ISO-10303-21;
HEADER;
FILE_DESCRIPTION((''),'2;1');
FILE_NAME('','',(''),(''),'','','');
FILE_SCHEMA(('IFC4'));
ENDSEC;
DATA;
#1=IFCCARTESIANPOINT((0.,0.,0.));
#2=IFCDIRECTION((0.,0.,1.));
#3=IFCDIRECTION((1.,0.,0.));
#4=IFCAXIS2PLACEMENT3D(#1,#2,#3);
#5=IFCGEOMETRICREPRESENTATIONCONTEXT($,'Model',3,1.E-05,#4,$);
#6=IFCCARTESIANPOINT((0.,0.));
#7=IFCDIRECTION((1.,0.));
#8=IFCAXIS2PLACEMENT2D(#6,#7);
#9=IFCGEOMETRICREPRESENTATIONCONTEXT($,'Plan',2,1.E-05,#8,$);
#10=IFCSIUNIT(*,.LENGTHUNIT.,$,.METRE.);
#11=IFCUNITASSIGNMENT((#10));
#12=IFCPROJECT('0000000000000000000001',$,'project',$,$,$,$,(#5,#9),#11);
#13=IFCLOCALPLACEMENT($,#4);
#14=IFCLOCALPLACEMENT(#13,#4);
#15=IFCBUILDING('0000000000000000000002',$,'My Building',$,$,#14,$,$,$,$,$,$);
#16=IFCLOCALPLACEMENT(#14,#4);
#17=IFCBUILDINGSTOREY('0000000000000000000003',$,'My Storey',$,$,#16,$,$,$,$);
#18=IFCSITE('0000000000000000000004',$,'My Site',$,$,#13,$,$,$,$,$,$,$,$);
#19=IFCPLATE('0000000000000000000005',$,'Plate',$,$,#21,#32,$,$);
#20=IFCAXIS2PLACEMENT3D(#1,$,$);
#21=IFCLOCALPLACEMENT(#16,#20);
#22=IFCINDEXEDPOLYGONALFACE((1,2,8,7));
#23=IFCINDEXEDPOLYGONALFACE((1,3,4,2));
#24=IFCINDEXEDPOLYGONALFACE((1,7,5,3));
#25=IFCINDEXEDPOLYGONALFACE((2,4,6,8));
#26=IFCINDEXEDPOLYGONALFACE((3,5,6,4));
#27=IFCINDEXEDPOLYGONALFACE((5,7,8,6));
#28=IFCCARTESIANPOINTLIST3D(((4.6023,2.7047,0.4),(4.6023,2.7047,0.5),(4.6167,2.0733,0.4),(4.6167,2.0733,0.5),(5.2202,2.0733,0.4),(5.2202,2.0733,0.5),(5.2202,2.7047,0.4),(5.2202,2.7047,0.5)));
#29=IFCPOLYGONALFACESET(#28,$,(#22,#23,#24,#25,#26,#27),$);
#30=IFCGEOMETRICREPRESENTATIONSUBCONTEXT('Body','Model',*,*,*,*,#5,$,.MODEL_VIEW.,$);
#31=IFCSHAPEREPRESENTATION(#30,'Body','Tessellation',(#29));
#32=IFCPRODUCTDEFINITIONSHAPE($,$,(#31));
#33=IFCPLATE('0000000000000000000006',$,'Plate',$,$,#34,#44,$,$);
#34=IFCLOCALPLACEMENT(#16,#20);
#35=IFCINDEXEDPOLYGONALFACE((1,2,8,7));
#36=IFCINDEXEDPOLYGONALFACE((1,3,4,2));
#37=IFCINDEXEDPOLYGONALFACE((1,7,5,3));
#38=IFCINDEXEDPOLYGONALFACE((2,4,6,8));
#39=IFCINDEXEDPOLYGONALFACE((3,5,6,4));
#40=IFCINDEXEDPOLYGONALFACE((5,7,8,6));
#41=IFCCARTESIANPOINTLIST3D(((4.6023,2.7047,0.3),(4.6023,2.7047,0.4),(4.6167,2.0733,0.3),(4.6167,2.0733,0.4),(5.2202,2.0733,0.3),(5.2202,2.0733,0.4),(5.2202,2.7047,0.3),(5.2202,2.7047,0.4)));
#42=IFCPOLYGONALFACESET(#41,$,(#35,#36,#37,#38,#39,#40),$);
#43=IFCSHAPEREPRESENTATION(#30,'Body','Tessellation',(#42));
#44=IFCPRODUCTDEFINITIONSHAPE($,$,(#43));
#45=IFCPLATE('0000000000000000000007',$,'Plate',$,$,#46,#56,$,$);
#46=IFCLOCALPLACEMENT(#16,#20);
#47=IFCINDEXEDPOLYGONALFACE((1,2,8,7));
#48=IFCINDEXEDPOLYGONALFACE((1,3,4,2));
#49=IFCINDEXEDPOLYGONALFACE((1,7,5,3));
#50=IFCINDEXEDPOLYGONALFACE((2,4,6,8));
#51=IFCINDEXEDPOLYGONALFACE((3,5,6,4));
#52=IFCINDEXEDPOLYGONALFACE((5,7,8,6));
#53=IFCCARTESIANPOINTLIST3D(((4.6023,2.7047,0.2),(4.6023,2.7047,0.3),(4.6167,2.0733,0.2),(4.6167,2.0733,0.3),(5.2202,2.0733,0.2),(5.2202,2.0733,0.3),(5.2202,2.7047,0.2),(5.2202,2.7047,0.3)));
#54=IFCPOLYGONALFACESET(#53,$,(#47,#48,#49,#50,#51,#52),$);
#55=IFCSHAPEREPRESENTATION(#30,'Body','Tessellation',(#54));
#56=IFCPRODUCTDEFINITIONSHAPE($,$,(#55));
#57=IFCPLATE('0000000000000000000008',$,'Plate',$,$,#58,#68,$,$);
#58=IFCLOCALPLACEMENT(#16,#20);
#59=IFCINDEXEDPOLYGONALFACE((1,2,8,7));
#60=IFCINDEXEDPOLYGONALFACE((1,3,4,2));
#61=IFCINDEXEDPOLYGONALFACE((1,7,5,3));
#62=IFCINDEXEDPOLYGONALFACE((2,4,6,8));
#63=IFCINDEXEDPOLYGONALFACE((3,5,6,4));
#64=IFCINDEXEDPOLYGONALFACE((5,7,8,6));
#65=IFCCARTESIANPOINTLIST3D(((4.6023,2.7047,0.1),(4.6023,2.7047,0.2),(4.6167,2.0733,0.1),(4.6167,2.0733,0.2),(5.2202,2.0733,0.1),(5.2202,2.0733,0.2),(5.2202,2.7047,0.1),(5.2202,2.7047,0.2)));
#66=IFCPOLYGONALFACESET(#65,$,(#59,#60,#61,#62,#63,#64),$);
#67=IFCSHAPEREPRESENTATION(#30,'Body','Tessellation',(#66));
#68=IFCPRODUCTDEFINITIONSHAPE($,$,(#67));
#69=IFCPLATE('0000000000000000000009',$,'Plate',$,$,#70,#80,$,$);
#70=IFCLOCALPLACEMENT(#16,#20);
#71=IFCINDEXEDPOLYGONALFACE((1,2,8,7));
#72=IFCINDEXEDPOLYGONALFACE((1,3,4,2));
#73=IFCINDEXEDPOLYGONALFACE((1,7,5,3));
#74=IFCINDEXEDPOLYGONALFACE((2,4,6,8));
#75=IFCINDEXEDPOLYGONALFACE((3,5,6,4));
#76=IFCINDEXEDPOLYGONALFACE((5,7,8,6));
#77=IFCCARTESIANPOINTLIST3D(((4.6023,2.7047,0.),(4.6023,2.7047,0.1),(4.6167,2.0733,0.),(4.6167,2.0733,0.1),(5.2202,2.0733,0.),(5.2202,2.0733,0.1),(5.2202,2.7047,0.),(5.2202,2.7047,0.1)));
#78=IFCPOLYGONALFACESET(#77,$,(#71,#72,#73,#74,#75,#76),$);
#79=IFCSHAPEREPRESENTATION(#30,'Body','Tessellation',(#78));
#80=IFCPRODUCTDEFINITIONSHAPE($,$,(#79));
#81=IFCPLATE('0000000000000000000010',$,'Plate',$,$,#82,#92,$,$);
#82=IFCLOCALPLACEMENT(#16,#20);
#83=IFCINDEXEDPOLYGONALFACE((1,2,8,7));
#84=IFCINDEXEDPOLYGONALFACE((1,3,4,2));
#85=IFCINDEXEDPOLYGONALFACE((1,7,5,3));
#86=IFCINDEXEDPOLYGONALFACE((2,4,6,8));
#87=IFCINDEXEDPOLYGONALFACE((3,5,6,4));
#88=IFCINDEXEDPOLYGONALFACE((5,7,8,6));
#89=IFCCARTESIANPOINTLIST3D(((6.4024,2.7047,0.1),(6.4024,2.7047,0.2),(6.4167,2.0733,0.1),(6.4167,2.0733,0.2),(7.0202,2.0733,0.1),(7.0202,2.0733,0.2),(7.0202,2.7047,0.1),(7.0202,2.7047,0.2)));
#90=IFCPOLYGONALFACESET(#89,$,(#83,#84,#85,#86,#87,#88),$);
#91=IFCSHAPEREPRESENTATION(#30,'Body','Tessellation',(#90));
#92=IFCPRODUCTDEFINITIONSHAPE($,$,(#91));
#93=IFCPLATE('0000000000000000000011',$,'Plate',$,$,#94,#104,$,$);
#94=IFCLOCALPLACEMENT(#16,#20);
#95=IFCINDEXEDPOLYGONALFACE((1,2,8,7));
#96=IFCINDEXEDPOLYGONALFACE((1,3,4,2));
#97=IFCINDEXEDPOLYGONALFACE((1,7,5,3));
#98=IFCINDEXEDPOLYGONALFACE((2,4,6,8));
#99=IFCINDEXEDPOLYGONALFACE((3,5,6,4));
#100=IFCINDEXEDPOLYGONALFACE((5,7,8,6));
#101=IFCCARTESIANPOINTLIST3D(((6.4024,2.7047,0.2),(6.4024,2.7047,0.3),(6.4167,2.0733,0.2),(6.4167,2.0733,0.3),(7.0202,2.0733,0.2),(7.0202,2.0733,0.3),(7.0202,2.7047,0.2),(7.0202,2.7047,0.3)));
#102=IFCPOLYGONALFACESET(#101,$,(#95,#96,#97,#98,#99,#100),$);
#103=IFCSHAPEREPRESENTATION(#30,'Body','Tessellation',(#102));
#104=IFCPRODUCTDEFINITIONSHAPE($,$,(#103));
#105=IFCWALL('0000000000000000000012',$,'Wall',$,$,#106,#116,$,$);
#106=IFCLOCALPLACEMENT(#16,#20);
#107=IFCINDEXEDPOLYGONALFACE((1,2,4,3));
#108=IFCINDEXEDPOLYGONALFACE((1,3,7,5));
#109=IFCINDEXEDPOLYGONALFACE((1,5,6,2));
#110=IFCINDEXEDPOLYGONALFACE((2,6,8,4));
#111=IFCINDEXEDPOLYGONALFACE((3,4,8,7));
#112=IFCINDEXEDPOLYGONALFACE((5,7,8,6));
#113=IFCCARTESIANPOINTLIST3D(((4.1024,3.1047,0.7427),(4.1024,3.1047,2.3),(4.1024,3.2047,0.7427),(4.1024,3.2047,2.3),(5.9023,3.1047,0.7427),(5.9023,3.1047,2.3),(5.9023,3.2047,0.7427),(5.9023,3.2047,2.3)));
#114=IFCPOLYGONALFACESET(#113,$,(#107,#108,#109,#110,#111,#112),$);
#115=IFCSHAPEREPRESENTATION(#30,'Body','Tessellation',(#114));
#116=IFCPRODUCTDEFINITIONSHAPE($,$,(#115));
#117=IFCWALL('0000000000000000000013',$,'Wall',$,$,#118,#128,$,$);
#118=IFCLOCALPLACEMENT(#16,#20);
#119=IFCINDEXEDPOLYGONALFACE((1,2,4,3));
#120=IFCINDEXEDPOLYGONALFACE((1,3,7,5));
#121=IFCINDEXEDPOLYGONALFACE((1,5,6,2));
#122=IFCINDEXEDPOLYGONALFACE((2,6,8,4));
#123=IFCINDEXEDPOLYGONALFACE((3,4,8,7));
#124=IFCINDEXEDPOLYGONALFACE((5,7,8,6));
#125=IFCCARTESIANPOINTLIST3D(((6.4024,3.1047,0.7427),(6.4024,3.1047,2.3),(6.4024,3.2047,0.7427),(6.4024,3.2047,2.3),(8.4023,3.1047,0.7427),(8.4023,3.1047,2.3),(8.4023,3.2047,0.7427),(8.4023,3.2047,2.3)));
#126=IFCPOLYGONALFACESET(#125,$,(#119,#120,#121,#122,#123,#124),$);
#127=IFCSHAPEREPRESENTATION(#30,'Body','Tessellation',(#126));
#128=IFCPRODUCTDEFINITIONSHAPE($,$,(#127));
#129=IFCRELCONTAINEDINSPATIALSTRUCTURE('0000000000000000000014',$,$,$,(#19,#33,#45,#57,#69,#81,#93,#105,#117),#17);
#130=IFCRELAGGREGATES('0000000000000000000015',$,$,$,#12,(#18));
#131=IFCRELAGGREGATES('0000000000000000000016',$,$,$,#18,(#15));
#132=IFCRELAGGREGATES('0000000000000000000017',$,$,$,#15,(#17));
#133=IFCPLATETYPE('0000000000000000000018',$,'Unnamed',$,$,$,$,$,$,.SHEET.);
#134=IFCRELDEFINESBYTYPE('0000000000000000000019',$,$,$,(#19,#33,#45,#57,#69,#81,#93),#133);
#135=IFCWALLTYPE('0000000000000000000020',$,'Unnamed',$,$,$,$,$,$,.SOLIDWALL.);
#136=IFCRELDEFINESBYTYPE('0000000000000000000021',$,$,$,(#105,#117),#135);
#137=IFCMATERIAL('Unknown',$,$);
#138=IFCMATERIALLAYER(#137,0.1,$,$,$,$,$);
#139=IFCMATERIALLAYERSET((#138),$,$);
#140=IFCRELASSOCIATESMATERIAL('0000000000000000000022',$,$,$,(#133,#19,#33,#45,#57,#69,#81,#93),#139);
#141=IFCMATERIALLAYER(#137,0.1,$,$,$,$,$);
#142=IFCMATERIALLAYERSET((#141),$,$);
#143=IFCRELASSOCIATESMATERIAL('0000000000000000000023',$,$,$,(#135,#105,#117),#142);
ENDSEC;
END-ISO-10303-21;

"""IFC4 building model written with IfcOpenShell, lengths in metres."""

from ifc_helpers import new_model, si_unit, frame, origin_with_axes, origin_2d_with_axis, place, context, subcontext, project, spatial, line, indexed_curve, outline, extrude, material, layer, layer_set, layer_usage, type_object, element, save


model = new_model("IFC4")

# Units and contexts
model_context = context("Model", 3, precision=1e-05, world=origin_with_axes())
plan_context = context("Plan", 2, precision=1e-05, world=origin_2d_with_axis())
body_context = subcontext(model_context, "Body", "Model", "MODEL_VIEW")
ifc_project = project(units=[si_unit("LENGTHUNIT", "METRE")], contexts=[model_context, plan_context])

# Site, building, storey
site_placement = place(None, origin_with_axes())
site = spatial("IfcSite", under=ifc_project, at=site_placement, Name="My Site")
building_placement = place(site_placement, origin_with_axes())
building = spatial("IfcBuilding", under=site, at=building_placement, Name="My Building")
storey_placement = place(building_placement, origin_with_axes())
storey = spatial("IfcBuildingStorey", under=building, at=storey_placement, Name="My Storey")

# Shared definitions
ifc_material = material(Name="Unknown")

# Plates
ifc_layer_1 = layer(ifc_material, 0.1)
ifc_layer_set_1 = layer_set([ifc_layer_1])
plate_type = type_object("IfcPlateType", Name="Unnamed", PredefinedType="SHEET", material=ifc_layer_set_1)
ifc_layer_usage_1 = layer_usage(ifc_layer_set_1, "AXIS3", "POSITIVE", -0.1)
plate_1_placement = place(storey_placement, frame((4.6167, 2.0733, 0.5), z_axis=(0.0, 0.0, 1.0), x_axis=(1.0, 0.0, 0.0)))
element("IfcPlate", 1, at=plate_1_placement, inside=storey, type_object=plate_type, material=ifc_layer_usage_1, Name="Plate", context=body_context, shape_type="SweptSolid", body=[
    extrude(outline(indexed_curve([(0.0, 0.0), (0.6036, 0.0), (0.6036, 0.6314), (-0.0143, 0.6314), (0.0, 0.0)])), frame((0.0, 0.0, -0.1), z_axis=(0.0, 0.0, 1.0), x_axis=(1.0, 0.0, 0.0)), (0.0, 0.0, 1.0), 0.1),
])
ifc_layer_usage_2 = layer_usage(ifc_layer_set_1, "AXIS3", "POSITIVE", -0.1)
plate_2_placement = place(storey_placement, frame((4.6167, 2.0733, 0.4), z_axis=(0.0, 0.0, 1.0), x_axis=(1.0, 0.0, 0.0)))
element("IfcPlate", 2, at=plate_2_placement, inside=storey, type_object=plate_type, material=ifc_layer_usage_2, Name="Plate", context=body_context, shape_type="SweptSolid", body=[
    extrude(outline(indexed_curve([(0.0, 0.0), (0.6036, 0.0), (0.6036, 0.6314), (-0.0143, 0.6314), (0.0, 0.0)])), frame((0.0, 0.0, -0.1), z_axis=(0.0, 0.0, 1.0), x_axis=(1.0, 0.0, 0.0)), (0.0, 0.0, 1.0), 0.1),
])
ifc_layer_usage_3 = layer_usage(ifc_layer_set_1, "AXIS3", "POSITIVE", -0.1)
plate_3_placement = place(storey_placement, frame((4.6167, 2.0733, 0.3), z_axis=(0.0, 0.0, 1.0), x_axis=(1.0, 0.0, 0.0)))
element("IfcPlate", 3, at=plate_3_placement, inside=storey, type_object=plate_type, material=ifc_layer_usage_3, Name="Plate", context=body_context, shape_type="SweptSolid", body=[
    extrude(outline(indexed_curve([(0.0, 0.0), (0.6036, 0.0), (0.6036, 0.6314), (-0.0143, 0.6314), (0.0, 0.0)])), frame((0.0, 0.0, -0.1), z_axis=(0.0, 0.0, 1.0), x_axis=(1.0, 0.0, 0.0)), (0.0, 0.0, 1.0), 0.1),
])
ifc_layer_usage_4 = layer_usage(ifc_layer_set_1, "AXIS3", "POSITIVE", -0.1)
plate_4_placement = place(storey_placement, frame((4.6167, 2.0733, 0.2), z_axis=(0.0, 0.0, 1.0), x_axis=(1.0, 0.0, 0.0)))
element("IfcPlate", 4, at=plate_4_placement, inside=storey, type_object=plate_type, material=ifc_layer_usage_4, Name="Plate", context=body_context, shape_type="SweptSolid", body=[
    extrude(outline(indexed_curve([(0.0, 0.0), (0.6036, 0.0), (0.6036, 0.6314), (-0.0143, 0.6314), (0.0, 0.0)])), frame((0.0, 0.0, -0.1), z_axis=(0.0, 0.0, 1.0), x_axis=(1.0, 0.0, 0.0)), (0.0, 0.0, 1.0), 0.1),
])
ifc_layer_usage_5 = layer_usage(ifc_layer_set_1, "AXIS3", "POSITIVE", -0.1)
plate_5_placement = place(storey_placement, frame((4.6167, 2.0733, 0.1), z_axis=(0.0, 0.0, 1.0), x_axis=(1.0, 0.0, 0.0)))
element("IfcPlate", 5, at=plate_5_placement, inside=storey, type_object=plate_type, material=ifc_layer_usage_5, Name="Plate", context=body_context, shape_type="SweptSolid", body=[
    extrude(outline(indexed_curve([(0.0, 0.0), (0.6036, 0.0), (0.6036, 0.6314), (-0.0143, 0.6314), (0.0, 0.0)])), frame((0.0, 0.0, -0.1), z_axis=(0.0, 0.0, 1.0), x_axis=(1.0, 0.0, 0.0)), (0.0, 0.0, 1.0), 0.1),
])
ifc_layer_usage_6 = layer_usage(ifc_layer_set_1, "AXIS3", "POSITIVE", -0.1)
plate_6_placement = place(storey_placement, frame((6.4167, 2.0733, 0.2), z_axis=(0.0, 0.0, 1.0), x_axis=(1.0, 0.0, 0.0)))
element("IfcPlate", 6, at=plate_6_placement, inside=storey, type_object=plate_type, material=ifc_layer_usage_6, Name="Plate", context=body_context, shape_type="SweptSolid", body=[
    extrude(outline(indexed_curve([(0.0, 0.0), (0.6036, 0.0), (0.6036, 0.6314), (-0.0143, 0.6314), (0.0, 0.0)])), frame((0.0, 0.0, -0.1), z_axis=(0.0, 0.0, 1.0), x_axis=(1.0, 0.0, 0.0)), (0.0, 0.0, 1.0), 0.1),
])
ifc_layer_usage_7 = layer_usage(ifc_layer_set_1, "AXIS3", "POSITIVE", -0.1)
plate_7_placement = place(storey_placement, frame((6.4167, 2.0733, 0.3), z_axis=(0.0, 0.0, 1.0), x_axis=(1.0, 0.0, 0.0)))
element("IfcPlate", 7, at=plate_7_placement, inside=storey, type_object=plate_type, material=ifc_layer_usage_7, Name="Plate", context=body_context, shape_type="SweptSolid", body=[
    extrude(outline(indexed_curve([(0.0, 0.0), (0.6036, 0.0), (0.6036, 0.6314), (-0.0143, 0.6314), (0.0, 0.0)])), frame((0.0, 0.0, -0.1), z_axis=(0.0, 0.0, 1.0), x_axis=(1.0, 0.0, 0.0)), (0.0, 0.0, 1.0), 0.1),
])

# Walls
ifc_layer_2 = layer(ifc_material, 0.1)
ifc_layer_set_2 = layer_set([ifc_layer_2])
ifc_layer_usage_8 = layer_usage(ifc_layer_set_2, "AXIS2", "POSITIVE", 0.0)
wall_type = type_object("IfcWallType", Name="Unnamed", PredefinedType="SOLIDWALL", material=ifc_layer_set_2)
wall_1_placement = place(storey_placement, frame((4.1024, 3.1047, 0.7427), z_axis=(0.0, 0.0, 1.0), x_axis=(1.0, 0.0, 0.0)))
element("IfcWall", 8, at=wall_1_placement, inside=storey, type_object=wall_type, material=ifc_layer_usage_8, Name="Wall", context=body_context, shape_type="SweptSolid", body=[
    extrude(outline(indexed_curve([(0.0, 0.0), (0.0, 0.1), (1.7999, 0.1), (1.7999, 0.0)], segments=[line(1, 2, 3, 4, 1)])), origin_with_axes(), (0.0, 0.0, 1.0), 1.5573),
])
ifc_layer_usage_9 = layer_usage(ifc_layer_set_2, "AXIS2", "POSITIVE", 0.0)
wall_2_placement = place(storey_placement, frame((6.4024, 3.1047, 0.7427), z_axis=(0.0, 0.0, 1.0), x_axis=(1.0, 0.0, 0.0)))
element("IfcWall", 9, at=wall_2_placement, inside=storey, type_object=wall_type, material=ifc_layer_usage_9, Name="Wall", context=body_context, shape_type="SweptSolid", body=[
    extrude(outline(indexed_curve([(0.0, 0.0), (0.0, 0.1), (2.0, 0.1), (2.0, 0.0)], segments=[line(1, 2, 3, 4, 1)])), origin_with_axes(), (0.0, 0.0, 1.0), 1.5573),
])

save(model, "model.ifc")
